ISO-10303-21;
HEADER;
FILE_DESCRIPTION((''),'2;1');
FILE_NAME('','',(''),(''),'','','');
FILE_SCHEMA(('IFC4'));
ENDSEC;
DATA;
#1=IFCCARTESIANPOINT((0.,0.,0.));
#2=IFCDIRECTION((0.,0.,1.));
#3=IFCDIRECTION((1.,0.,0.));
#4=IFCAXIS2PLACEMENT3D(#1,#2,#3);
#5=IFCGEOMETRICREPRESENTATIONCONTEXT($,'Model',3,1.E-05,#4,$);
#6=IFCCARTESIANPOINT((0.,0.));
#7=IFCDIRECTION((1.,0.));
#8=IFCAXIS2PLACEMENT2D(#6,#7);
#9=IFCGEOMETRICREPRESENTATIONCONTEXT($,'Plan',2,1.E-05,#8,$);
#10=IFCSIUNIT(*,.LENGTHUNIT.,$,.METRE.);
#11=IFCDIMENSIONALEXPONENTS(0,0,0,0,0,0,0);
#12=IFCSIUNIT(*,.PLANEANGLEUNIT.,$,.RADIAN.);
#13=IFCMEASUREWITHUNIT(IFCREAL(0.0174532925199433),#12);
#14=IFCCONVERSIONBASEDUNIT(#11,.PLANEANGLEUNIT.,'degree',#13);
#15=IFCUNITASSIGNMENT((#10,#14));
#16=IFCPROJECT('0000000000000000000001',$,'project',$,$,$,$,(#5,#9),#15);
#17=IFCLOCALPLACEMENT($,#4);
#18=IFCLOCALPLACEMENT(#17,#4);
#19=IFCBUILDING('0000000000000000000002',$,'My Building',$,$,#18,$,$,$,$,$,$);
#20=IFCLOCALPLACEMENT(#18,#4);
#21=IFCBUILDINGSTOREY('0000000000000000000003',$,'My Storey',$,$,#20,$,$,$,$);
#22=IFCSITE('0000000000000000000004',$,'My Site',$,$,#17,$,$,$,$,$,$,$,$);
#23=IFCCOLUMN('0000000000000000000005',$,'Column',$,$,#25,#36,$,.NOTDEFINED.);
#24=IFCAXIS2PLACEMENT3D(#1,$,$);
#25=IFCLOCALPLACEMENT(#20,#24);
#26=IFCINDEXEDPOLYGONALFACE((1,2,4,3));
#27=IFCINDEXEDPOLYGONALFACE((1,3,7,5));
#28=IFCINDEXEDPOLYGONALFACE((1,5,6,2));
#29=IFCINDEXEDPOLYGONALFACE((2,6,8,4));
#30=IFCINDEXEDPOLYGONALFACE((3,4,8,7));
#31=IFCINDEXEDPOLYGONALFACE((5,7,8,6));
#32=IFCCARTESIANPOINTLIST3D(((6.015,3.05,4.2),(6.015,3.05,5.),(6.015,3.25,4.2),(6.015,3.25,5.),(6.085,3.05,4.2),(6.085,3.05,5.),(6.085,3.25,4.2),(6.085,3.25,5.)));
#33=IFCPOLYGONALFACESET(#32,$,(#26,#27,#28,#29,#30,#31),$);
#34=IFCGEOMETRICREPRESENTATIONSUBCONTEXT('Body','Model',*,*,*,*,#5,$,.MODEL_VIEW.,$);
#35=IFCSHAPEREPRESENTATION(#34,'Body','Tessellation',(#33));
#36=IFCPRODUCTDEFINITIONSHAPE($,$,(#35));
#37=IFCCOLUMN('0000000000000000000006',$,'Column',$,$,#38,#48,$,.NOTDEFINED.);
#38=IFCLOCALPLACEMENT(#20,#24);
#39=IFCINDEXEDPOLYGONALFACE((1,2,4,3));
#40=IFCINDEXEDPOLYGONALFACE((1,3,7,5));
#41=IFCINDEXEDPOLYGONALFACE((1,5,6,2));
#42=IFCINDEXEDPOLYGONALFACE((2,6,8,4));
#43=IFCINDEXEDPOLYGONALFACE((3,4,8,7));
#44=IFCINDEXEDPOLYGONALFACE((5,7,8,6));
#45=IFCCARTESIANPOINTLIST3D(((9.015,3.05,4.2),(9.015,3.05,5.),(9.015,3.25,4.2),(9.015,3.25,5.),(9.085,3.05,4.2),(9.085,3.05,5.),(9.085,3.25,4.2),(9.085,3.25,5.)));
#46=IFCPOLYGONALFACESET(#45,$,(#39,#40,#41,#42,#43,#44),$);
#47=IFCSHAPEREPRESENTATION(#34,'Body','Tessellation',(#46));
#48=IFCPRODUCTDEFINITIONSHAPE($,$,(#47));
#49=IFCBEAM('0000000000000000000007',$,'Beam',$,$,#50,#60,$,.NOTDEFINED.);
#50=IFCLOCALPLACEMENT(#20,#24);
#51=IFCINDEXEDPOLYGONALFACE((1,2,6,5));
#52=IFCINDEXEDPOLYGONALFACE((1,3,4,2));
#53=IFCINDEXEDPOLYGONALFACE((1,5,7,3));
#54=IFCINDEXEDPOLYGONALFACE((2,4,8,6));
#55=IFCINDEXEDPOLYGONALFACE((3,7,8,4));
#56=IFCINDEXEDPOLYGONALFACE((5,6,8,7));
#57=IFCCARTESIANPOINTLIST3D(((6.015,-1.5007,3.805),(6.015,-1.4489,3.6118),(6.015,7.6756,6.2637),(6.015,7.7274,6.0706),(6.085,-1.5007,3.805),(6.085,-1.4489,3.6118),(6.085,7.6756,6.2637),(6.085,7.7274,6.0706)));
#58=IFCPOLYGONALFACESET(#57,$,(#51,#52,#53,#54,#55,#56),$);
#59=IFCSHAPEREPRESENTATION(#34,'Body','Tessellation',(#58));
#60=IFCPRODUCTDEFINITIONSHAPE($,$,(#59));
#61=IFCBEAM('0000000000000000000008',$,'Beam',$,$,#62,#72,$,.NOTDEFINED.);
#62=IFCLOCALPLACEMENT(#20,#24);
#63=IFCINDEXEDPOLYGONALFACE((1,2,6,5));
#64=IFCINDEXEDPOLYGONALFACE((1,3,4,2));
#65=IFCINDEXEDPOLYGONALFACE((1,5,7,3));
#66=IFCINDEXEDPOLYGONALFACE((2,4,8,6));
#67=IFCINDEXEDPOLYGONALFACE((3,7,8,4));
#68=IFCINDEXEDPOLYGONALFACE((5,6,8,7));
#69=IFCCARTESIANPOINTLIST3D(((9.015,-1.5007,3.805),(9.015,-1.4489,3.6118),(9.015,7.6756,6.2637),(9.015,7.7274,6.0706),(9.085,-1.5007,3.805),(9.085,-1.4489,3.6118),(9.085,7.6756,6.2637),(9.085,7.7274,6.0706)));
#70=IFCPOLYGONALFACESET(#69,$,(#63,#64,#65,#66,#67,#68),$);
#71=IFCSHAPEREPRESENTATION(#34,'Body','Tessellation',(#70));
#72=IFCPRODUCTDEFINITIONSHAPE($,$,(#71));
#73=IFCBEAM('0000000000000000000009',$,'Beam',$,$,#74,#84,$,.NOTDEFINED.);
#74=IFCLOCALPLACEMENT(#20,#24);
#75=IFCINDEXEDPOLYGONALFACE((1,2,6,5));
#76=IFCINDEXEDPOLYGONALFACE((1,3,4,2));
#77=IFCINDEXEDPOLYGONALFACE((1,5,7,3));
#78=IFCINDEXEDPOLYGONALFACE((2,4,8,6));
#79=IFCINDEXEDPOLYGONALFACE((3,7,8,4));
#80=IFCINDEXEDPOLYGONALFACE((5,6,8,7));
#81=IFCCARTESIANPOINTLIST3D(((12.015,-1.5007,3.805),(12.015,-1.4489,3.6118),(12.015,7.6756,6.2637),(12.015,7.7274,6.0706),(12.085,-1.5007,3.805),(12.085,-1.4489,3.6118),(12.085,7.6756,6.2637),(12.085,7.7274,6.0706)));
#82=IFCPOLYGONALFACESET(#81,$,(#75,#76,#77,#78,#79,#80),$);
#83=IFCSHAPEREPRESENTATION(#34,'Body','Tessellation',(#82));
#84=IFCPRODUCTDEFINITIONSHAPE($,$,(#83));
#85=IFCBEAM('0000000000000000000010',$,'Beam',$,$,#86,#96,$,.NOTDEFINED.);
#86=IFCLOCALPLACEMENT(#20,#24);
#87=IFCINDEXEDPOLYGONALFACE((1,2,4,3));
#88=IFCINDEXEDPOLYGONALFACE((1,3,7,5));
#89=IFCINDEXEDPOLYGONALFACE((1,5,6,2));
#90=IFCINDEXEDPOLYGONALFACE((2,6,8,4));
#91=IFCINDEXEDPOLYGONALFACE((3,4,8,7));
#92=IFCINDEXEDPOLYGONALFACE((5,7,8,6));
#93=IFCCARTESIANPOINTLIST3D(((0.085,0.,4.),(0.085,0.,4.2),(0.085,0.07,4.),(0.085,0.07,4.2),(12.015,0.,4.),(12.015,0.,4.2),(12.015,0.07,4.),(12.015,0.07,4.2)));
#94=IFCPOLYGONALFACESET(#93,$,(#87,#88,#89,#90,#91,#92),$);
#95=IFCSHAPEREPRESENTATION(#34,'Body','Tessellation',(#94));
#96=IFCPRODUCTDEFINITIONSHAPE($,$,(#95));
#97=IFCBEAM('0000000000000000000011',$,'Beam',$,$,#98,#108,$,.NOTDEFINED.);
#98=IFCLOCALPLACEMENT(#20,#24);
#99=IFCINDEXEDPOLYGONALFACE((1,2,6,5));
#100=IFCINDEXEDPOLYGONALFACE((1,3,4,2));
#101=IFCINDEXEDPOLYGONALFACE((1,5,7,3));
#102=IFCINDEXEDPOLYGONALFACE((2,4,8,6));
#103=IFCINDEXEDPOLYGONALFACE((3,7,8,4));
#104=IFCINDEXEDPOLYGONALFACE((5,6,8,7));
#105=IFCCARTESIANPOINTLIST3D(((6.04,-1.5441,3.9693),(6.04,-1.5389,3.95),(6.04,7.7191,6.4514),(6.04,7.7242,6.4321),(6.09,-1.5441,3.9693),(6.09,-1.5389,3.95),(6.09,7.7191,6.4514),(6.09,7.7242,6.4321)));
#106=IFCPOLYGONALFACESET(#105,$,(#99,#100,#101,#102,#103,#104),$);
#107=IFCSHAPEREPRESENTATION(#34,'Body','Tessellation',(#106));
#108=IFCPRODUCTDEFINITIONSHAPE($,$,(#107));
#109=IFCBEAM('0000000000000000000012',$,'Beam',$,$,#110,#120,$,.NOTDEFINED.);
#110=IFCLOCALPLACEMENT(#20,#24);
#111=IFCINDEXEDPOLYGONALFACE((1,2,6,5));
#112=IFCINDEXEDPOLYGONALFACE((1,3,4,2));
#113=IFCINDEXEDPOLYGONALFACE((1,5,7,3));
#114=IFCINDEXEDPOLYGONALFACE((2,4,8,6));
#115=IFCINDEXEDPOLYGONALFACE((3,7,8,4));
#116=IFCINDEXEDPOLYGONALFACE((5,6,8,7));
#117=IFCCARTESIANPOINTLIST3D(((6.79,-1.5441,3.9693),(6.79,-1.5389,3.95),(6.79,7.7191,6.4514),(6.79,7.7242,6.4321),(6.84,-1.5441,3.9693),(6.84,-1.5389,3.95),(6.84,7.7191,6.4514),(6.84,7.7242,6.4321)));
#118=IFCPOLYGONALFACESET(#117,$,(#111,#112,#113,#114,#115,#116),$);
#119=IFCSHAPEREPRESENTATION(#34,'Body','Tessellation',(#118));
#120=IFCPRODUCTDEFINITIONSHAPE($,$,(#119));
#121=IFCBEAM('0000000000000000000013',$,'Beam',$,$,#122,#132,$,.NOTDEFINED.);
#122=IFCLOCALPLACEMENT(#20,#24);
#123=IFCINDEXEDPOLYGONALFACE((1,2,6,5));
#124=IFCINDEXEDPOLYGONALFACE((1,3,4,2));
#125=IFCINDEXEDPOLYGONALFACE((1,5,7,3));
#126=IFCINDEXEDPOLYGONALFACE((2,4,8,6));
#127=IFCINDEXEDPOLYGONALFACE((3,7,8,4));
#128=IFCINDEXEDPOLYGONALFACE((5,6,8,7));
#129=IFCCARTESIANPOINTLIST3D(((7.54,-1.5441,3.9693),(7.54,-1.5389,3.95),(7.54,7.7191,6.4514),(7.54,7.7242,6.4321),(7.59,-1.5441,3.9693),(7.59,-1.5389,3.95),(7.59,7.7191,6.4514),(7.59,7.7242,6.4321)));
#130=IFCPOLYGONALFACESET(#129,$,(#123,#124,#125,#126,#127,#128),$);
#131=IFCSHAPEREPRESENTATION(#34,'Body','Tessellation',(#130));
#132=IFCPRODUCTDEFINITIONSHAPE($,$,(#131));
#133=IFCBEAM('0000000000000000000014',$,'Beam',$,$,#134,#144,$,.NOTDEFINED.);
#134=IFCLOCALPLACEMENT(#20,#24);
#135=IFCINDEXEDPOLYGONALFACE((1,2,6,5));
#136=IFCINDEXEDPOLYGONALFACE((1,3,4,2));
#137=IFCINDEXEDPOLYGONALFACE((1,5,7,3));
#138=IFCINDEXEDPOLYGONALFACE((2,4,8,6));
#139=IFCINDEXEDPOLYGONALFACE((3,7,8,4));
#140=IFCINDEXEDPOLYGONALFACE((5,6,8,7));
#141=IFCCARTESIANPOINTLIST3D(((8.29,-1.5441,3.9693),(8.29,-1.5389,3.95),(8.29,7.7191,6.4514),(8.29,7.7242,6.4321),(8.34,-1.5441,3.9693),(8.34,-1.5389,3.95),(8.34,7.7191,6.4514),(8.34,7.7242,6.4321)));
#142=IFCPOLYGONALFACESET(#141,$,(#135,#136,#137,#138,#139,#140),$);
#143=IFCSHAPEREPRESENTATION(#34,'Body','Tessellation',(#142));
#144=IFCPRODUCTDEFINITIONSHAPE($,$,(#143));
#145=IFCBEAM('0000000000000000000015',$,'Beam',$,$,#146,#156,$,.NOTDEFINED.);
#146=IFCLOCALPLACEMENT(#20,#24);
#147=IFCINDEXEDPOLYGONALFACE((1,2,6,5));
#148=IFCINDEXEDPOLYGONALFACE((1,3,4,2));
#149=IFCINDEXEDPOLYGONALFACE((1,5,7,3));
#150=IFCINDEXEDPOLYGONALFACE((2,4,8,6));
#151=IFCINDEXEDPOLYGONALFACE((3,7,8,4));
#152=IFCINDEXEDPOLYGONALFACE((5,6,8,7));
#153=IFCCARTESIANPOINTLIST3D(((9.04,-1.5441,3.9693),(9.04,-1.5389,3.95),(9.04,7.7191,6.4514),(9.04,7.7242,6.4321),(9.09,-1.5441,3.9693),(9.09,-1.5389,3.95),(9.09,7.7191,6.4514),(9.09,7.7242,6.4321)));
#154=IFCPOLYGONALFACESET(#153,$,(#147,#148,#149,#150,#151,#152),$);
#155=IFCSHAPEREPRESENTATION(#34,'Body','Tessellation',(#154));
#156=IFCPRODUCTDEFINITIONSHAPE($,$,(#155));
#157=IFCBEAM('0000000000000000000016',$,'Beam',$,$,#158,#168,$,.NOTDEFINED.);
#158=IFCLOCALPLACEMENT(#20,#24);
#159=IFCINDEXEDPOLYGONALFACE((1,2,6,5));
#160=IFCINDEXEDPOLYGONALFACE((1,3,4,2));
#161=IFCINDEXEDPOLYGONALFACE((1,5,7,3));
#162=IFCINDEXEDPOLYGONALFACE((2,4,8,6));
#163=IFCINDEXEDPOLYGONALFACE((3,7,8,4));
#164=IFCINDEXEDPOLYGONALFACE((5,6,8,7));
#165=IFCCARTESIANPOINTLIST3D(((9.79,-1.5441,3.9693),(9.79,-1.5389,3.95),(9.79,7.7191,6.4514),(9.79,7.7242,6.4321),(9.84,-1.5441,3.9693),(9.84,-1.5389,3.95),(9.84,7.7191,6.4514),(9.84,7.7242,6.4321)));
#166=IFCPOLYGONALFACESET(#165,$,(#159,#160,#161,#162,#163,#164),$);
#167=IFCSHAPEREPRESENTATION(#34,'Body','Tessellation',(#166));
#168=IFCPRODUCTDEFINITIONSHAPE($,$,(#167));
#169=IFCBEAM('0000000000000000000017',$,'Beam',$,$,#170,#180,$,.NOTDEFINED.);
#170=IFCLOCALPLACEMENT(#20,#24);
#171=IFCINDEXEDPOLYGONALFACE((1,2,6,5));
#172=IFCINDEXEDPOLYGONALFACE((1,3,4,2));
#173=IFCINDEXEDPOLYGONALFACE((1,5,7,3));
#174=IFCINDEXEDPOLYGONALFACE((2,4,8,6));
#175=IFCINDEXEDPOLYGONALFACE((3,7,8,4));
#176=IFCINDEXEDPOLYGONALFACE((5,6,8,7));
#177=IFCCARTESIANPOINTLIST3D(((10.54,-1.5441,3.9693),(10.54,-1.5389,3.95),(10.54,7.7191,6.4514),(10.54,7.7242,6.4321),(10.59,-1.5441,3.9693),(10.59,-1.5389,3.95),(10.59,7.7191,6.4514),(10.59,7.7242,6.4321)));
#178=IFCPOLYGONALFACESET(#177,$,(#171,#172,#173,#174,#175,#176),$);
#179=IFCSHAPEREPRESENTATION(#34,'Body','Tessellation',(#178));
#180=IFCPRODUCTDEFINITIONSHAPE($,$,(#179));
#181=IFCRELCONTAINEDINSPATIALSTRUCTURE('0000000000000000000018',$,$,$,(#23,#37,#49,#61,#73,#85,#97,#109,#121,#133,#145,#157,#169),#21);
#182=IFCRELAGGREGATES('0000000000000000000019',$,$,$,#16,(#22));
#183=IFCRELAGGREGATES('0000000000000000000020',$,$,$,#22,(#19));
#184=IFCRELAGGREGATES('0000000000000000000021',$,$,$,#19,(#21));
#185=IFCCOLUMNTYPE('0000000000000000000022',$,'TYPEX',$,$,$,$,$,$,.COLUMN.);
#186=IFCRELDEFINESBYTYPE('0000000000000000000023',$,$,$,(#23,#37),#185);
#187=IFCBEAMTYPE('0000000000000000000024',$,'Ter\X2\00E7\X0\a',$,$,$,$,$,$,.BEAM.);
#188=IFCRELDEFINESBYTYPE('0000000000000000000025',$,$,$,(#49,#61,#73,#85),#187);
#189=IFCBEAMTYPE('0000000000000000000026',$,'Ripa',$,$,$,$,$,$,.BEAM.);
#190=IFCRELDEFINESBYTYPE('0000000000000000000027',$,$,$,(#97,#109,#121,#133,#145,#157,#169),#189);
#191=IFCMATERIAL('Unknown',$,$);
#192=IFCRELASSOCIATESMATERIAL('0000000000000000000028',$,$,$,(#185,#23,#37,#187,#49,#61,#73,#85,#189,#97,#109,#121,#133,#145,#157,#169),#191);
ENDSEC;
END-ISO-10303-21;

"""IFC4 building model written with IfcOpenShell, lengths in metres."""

from ifc_helpers import new_model, entity, si_unit, converted_unit, frame, origin_with_axes, origin_2d_with_axis, place, context, subcontext, project, spatial, rectangle, extrude, material, material_profile, profile_set, profile_usage, type_object, element, save


model = new_model("IFC4")

# Units and contexts
model_context = context("Model", 3, precision=1e-05, world=origin_with_axes())
plan_context = context("Plan", 2, precision=1e-05, world=origin_2d_with_axis())
body_context = subcontext(model_context, "Body", "Model", "MODEL_VIEW")
ifc_project = project(units=[si_unit("LENGTHUNIT", "METRE"), converted_unit("PLANEANGLEUNIT", "degree", entity("IfcReal", 0.0174532925199433), si_unit("PLANEANGLEUNIT", "RADIAN"), dimensions=[0, 0, 0, 0, 0, 0, 0])], contexts=[model_context, plan_context])

# Site, building, storey
site_placement = place(None, origin_with_axes())
site = spatial("IfcSite", under=ifc_project, at=site_placement, Name="My Site")
building_placement = place(site_placement, origin_with_axes())
building = spatial("IfcBuilding", under=site, at=building_placement, Name="My Building")
storey_placement = place(building_placement, origin_with_axes())
storey = spatial("IfcBuildingStorey", under=building, at=storey_placement, Name="My Storey")

# Columns
ifc_material_1 = material(Name="Unknown")
ifc_material_profile_1 = material_profile(ifc_material_1, rectangle(XDim=0.07, YDim=0.2))
ifc_profile_set_1 = profile_set([ifc_material_profile_1])
ifc_profile_usage_1 = profile_usage(ifc_profile_set_1, cardinal=2)
column_type = type_object("IfcColumnType", Name="TYPEX", PredefinedType="COLUMN", material=ifc_profile_set_1)
column_1_placement = place(storey_placement, frame((6.05, 3.25, 4.2), z_axis=(0.0, 0.0, 1.0), x_axis=(-1.0, 0.0, 0.0)))
element("IfcColumn", 1, at=column_1_placement, inside=storey, type_object=column_type, material=ifc_profile_usage_1, Name="Column", PredefinedType="NOTDEFINED", context=body_context, shape_type="SweptSolid", body=[
    extrude(rectangle(XDim=0.07, YDim=0.2), frame((0.0, 0.1, 0.0), z_axis=(0.0, 0.0, 1.0), x_axis=(1.0, 0.0, 0.0)), (0.0, 0.0, 1.0), 0.8),
])
ifc_profile_usage_2 = profile_usage(ifc_profile_set_1, cardinal=2)
column_2_placement = place(storey_placement, frame((9.05, 3.25, 4.2), z_axis=(0.0, 0.0, 1.0), x_axis=(-1.0, 0.0, 0.0)))
element("IfcColumn", 2, at=column_2_placement, inside=storey, type_object=column_type, material=ifc_profile_usage_2, Name="Column", PredefinedType="NOTDEFINED", context=body_context, shape_type="SweptSolid", body=[
    extrude(rectangle(XDim=0.07, YDim=0.2), frame((0.0, 0.1, 0.0), z_axis=(0.0, 0.0, 1.0), x_axis=(1.0, 0.0, 0.0)), (0.0, 0.0, 1.0), 0.8),
])

# Beams
ifc_material_profile_2 = material_profile(ifc_material_1, rectangle(XDim=0.07, YDim=0.2))
ifc_profile_set_2 = profile_set([ifc_material_profile_2])
ifc_profile_usage_3 = profile_usage(ifc_profile_set_2, cardinal=2)
beam_type_1 = type_object("IfcBeamType", Name="Terça", PredefinedType="BEAM", material=ifc_profile_set_2)
beam_1_placement = place(storey_placement, frame((6.05, -1.4489, 3.6118), z_axis=(0.0, 0.965926, 0.258819), x_axis=(-1.0, 0.0, 0.0)))
element("IfcBeam", 3, at=beam_1_placement, inside=storey, type_object=beam_type_1, material=ifc_profile_usage_3, Name="Beam", PredefinedType="NOTDEFINED", context=body_context, shape_type="SweptSolid", body=[
    extrude(rectangle(XDim=0.07, YDim=0.2), frame((0.0, 0.1, 0.0), z_axis=(0.0, 0.0, 1.0), x_axis=(1.0, 0.0, 0.0)), (0.0, 0.0, 1.0), 9.5),
])
ifc_profile_usage_4 = profile_usage(ifc_profile_set_2, cardinal=2)
beam_2_placement = place(storey_placement, frame((9.05, -1.4489, 3.6118), z_axis=(0.0, 0.965926, 0.258819), x_axis=(-1.0, 0.0, 0.0)))
element("IfcBeam", 4, at=beam_2_placement, inside=storey, type_object=beam_type_1, material=ifc_profile_usage_4, Name="Beam", PredefinedType="NOTDEFINED", context=body_context, shape_type="SweptSolid", body=[
    extrude(rectangle(XDim=0.07, YDim=0.2), frame((0.0, 0.1, 0.0), z_axis=(0.0, 0.0, 1.0), x_axis=(1.0, 0.0, 0.0)), (0.0, 0.0, 1.0), 9.5),
])
ifc_profile_usage_5 = profile_usage(ifc_profile_set_2, cardinal=2)
beam_3_placement = place(storey_placement, frame((12.05, -1.4489, 3.6118), z_axis=(0.0, 0.965926, 0.258819), x_axis=(-1.0, 0.0, 0.0)))
element("IfcBeam", 5, at=beam_3_placement, inside=storey, type_object=beam_type_1, material=ifc_profile_usage_5, Name="Beam", PredefinedType="NOTDEFINED", context=body_context, shape_type="SweptSolid", body=[
    extrude(rectangle(XDim=0.07, YDim=0.2), frame((0.0, 0.1, 0.0), z_axis=(0.0, 0.0, 1.0), x_axis=(1.0, 0.0, 0.0)), (0.0, 0.0, 1.0), 9.5),
])
ifc_profile_usage_6 = profile_usage(ifc_profile_set_2, cardinal=2)
beam_4_placement = place(storey_placement, frame((12.015, 0.035, 4.0), z_axis=(-1.0, 0.0, 0.0), x_axis=(0.0, -1.0, 0.0)))
element("IfcBeam", 6, at=beam_4_placement, inside=storey, type_object=beam_type_1, material=ifc_profile_usage_6, Name="Beam", PredefinedType="NOTDEFINED", context=body_context, shape_type="SweptSolid", body=[
    extrude(rectangle(XDim=0.07, YDim=0.2), frame((0.0, 0.1, 0.0), z_axis=(0.0, 0.0, 1.0), x_axis=(1.0, 0.0, 0.0)), (0.0, 0.0, 1.0), 11.93),
])
ifc_material_profile_3 = material_profile(ifc_material_1, rectangle(XDim=0.05, YDim=0.02))
ifc_profile_set_3 = profile_set([ifc_material_profile_3])
ifc_profile_usage_7 = profile_usage(ifc_profile_set_3, cardinal=2)
beam_type_2 = type_object("IfcBeamType", Name="Ripa", PredefinedType="BEAM", material=ifc_profile_set_3)
beam_5_placement = place(storey_placement, frame((6.065, -1.5389, 3.95), z_axis=(-0.000001, 0.965926, 0.25882), x_axis=(-1.0, -0.000001, 0.0)))
element("IfcBeam", 7, at=beam_5_placement, inside=storey, type_object=beam_type_2, material=ifc_profile_usage_7, Name="Beam", PredefinedType="NOTDEFINED", context=body_context, shape_type="SweptSolid", body=[
    extrude(rectangle(XDim=0.05, YDim=0.02), frame((0.0, 0.01, 0.0), z_axis=(0.0, 0.0, 1.0), x_axis=(1.0, 0.0, 0.0)), (0.0, 0.0, 1.0), 9.5899),
])
ifc_profile_usage_8 = profile_usage(ifc_profile_set_3, cardinal=2)
beam_6_placement = place(storey_placement, frame((6.815, -1.5389, 3.95), z_axis=(-0.000001, 0.965926, 0.25882), x_axis=(-1.0, -0.000001, 0.0)))
element("IfcBeam", 8, at=beam_6_placement, inside=storey, type_object=beam_type_2, material=ifc_profile_usage_8, Name="Beam", PredefinedType="NOTDEFINED", context=body_context, shape_type="SweptSolid", body=[
    extrude(rectangle(XDim=0.05, YDim=0.02), frame((0.0, 0.01, 0.0), z_axis=(0.0, 0.0, 1.0), x_axis=(1.0, 0.0, 0.0)), (0.0, 0.0, 1.0), 9.5899),
])
ifc_profile_usage_9 = profile_usage(ifc_profile_set_3, cardinal=2)
beam_7_placement = place(storey_placement, frame((7.565, -1.5389, 3.95), z_axis=(-0.000001, 0.965926, 0.25882), x_axis=(-1.0, -0.000001, 0.0)))
element("IfcBeam", 9, at=beam_7_placement, inside=storey, type_object=beam_type_2, material=ifc_profile_usage_9, Name="Beam", PredefinedType="NOTDEFINED", context=body_context, shape_type="SweptSolid", body=[
    extrude(rectangle(XDim=0.05, YDim=0.02), frame((0.0, 0.01, 0.0), z_axis=(0.0, 0.0, 1.0), x_axis=(1.0, 0.0, 0.0)), (0.0, 0.0, 1.0), 9.5899),
])
ifc_profile_usage_10 = profile_usage(ifc_profile_set_3, cardinal=2)
beam_8_placement = place(storey_placement, frame((8.315, -1.5389, 3.95), z_axis=(-0.000001, 0.965926, 0.25882), x_axis=(-1.0, -0.000001, 0.0)))
element("IfcBeam", 10, at=beam_8_placement, inside=storey, type_object=beam_type_2, material=ifc_profile_usage_10, Name="Beam", PredefinedType="NOTDEFINED", context=body_context, shape_type="SweptSolid", body=[
    extrude(rectangle(XDim=0.05, YDim=0.02), frame((0.0, 0.01, 0.0), z_axis=(0.0, 0.0, 1.0), x_axis=(1.0, 0.0, 0.0)), (0.0, 0.0, 1.0), 9.5899),
])
ifc_profile_usage_11 = profile_usage(ifc_profile_set_3, cardinal=2)
beam_9_placement = place(storey_placement, frame((9.065, -1.5389, 3.95), z_axis=(-0.000001, 0.965926, 0.25882), x_axis=(-1.0, -0.000001, 0.0)))
element("IfcBeam", 11, at=beam_9_placement, inside=storey, type_object=beam_type_2, material=ifc_profile_usage_11, Name="Beam", PredefinedType="NOTDEFINED", context=body_context, shape_type="SweptSolid", body=[
    extrude(rectangle(XDim=0.05, YDim=0.02), frame((0.0, 0.01, 0.0), z_axis=(0.0, 0.0, 1.0), x_axis=(1.0, 0.0, 0.0)), (0.0, 0.0, 1.0), 9.5899),
])
ifc_profile_usage_12 = profile_usage(ifc_profile_set_3, cardinal=2)
beam_10_placement = place(storey_placement, frame((9.815, -1.5389, 3.95), z_axis=(-0.000001, 0.965926, 0.25882), x_axis=(-1.0, -0.000001, 0.0)))
element("IfcBeam", 12, at=beam_10_placement, inside=storey, type_object=beam_type_2, material=ifc_profile_usage_12, Name="Beam", PredefinedType="NOTDEFINED", context=body_context, shape_type="SweptSolid", body=[
    extrude(rectangle(XDim=0.05, YDim=0.02), frame((0.0, 0.01, 0.0), z_axis=(0.0, 0.0, 1.0), x_axis=(1.0, 0.0, 0.0)), (0.0, 0.0, 1.0), 9.5899),
])
ifc_profile_usage_13 = profile_usage(ifc_profile_set_3, cardinal=2)
beam_11_placement = place(storey_placement, frame((10.565, -1.5389, 3.95), z_axis=(-0.000001, 0.965926, 0.25882), x_axis=(-1.0, -0.000001, 0.0)))
element("IfcBeam", 13, at=beam_11_placement, inside=storey, type_object=beam_type_2, material=ifc_profile_usage_13, Name="Beam", PredefinedType="NOTDEFINED", context=body_context, shape_type="SweptSolid", body=[
    extrude(rectangle(XDim=0.05, YDim=0.02), frame((0.0, 0.01, 0.0), z_axis=(0.0, 0.0, 1.0), x_axis=(1.0, 0.0, 0.0)), (0.0, 0.0, 1.0), 9.5899),
])

save(model, "model.ifc")
